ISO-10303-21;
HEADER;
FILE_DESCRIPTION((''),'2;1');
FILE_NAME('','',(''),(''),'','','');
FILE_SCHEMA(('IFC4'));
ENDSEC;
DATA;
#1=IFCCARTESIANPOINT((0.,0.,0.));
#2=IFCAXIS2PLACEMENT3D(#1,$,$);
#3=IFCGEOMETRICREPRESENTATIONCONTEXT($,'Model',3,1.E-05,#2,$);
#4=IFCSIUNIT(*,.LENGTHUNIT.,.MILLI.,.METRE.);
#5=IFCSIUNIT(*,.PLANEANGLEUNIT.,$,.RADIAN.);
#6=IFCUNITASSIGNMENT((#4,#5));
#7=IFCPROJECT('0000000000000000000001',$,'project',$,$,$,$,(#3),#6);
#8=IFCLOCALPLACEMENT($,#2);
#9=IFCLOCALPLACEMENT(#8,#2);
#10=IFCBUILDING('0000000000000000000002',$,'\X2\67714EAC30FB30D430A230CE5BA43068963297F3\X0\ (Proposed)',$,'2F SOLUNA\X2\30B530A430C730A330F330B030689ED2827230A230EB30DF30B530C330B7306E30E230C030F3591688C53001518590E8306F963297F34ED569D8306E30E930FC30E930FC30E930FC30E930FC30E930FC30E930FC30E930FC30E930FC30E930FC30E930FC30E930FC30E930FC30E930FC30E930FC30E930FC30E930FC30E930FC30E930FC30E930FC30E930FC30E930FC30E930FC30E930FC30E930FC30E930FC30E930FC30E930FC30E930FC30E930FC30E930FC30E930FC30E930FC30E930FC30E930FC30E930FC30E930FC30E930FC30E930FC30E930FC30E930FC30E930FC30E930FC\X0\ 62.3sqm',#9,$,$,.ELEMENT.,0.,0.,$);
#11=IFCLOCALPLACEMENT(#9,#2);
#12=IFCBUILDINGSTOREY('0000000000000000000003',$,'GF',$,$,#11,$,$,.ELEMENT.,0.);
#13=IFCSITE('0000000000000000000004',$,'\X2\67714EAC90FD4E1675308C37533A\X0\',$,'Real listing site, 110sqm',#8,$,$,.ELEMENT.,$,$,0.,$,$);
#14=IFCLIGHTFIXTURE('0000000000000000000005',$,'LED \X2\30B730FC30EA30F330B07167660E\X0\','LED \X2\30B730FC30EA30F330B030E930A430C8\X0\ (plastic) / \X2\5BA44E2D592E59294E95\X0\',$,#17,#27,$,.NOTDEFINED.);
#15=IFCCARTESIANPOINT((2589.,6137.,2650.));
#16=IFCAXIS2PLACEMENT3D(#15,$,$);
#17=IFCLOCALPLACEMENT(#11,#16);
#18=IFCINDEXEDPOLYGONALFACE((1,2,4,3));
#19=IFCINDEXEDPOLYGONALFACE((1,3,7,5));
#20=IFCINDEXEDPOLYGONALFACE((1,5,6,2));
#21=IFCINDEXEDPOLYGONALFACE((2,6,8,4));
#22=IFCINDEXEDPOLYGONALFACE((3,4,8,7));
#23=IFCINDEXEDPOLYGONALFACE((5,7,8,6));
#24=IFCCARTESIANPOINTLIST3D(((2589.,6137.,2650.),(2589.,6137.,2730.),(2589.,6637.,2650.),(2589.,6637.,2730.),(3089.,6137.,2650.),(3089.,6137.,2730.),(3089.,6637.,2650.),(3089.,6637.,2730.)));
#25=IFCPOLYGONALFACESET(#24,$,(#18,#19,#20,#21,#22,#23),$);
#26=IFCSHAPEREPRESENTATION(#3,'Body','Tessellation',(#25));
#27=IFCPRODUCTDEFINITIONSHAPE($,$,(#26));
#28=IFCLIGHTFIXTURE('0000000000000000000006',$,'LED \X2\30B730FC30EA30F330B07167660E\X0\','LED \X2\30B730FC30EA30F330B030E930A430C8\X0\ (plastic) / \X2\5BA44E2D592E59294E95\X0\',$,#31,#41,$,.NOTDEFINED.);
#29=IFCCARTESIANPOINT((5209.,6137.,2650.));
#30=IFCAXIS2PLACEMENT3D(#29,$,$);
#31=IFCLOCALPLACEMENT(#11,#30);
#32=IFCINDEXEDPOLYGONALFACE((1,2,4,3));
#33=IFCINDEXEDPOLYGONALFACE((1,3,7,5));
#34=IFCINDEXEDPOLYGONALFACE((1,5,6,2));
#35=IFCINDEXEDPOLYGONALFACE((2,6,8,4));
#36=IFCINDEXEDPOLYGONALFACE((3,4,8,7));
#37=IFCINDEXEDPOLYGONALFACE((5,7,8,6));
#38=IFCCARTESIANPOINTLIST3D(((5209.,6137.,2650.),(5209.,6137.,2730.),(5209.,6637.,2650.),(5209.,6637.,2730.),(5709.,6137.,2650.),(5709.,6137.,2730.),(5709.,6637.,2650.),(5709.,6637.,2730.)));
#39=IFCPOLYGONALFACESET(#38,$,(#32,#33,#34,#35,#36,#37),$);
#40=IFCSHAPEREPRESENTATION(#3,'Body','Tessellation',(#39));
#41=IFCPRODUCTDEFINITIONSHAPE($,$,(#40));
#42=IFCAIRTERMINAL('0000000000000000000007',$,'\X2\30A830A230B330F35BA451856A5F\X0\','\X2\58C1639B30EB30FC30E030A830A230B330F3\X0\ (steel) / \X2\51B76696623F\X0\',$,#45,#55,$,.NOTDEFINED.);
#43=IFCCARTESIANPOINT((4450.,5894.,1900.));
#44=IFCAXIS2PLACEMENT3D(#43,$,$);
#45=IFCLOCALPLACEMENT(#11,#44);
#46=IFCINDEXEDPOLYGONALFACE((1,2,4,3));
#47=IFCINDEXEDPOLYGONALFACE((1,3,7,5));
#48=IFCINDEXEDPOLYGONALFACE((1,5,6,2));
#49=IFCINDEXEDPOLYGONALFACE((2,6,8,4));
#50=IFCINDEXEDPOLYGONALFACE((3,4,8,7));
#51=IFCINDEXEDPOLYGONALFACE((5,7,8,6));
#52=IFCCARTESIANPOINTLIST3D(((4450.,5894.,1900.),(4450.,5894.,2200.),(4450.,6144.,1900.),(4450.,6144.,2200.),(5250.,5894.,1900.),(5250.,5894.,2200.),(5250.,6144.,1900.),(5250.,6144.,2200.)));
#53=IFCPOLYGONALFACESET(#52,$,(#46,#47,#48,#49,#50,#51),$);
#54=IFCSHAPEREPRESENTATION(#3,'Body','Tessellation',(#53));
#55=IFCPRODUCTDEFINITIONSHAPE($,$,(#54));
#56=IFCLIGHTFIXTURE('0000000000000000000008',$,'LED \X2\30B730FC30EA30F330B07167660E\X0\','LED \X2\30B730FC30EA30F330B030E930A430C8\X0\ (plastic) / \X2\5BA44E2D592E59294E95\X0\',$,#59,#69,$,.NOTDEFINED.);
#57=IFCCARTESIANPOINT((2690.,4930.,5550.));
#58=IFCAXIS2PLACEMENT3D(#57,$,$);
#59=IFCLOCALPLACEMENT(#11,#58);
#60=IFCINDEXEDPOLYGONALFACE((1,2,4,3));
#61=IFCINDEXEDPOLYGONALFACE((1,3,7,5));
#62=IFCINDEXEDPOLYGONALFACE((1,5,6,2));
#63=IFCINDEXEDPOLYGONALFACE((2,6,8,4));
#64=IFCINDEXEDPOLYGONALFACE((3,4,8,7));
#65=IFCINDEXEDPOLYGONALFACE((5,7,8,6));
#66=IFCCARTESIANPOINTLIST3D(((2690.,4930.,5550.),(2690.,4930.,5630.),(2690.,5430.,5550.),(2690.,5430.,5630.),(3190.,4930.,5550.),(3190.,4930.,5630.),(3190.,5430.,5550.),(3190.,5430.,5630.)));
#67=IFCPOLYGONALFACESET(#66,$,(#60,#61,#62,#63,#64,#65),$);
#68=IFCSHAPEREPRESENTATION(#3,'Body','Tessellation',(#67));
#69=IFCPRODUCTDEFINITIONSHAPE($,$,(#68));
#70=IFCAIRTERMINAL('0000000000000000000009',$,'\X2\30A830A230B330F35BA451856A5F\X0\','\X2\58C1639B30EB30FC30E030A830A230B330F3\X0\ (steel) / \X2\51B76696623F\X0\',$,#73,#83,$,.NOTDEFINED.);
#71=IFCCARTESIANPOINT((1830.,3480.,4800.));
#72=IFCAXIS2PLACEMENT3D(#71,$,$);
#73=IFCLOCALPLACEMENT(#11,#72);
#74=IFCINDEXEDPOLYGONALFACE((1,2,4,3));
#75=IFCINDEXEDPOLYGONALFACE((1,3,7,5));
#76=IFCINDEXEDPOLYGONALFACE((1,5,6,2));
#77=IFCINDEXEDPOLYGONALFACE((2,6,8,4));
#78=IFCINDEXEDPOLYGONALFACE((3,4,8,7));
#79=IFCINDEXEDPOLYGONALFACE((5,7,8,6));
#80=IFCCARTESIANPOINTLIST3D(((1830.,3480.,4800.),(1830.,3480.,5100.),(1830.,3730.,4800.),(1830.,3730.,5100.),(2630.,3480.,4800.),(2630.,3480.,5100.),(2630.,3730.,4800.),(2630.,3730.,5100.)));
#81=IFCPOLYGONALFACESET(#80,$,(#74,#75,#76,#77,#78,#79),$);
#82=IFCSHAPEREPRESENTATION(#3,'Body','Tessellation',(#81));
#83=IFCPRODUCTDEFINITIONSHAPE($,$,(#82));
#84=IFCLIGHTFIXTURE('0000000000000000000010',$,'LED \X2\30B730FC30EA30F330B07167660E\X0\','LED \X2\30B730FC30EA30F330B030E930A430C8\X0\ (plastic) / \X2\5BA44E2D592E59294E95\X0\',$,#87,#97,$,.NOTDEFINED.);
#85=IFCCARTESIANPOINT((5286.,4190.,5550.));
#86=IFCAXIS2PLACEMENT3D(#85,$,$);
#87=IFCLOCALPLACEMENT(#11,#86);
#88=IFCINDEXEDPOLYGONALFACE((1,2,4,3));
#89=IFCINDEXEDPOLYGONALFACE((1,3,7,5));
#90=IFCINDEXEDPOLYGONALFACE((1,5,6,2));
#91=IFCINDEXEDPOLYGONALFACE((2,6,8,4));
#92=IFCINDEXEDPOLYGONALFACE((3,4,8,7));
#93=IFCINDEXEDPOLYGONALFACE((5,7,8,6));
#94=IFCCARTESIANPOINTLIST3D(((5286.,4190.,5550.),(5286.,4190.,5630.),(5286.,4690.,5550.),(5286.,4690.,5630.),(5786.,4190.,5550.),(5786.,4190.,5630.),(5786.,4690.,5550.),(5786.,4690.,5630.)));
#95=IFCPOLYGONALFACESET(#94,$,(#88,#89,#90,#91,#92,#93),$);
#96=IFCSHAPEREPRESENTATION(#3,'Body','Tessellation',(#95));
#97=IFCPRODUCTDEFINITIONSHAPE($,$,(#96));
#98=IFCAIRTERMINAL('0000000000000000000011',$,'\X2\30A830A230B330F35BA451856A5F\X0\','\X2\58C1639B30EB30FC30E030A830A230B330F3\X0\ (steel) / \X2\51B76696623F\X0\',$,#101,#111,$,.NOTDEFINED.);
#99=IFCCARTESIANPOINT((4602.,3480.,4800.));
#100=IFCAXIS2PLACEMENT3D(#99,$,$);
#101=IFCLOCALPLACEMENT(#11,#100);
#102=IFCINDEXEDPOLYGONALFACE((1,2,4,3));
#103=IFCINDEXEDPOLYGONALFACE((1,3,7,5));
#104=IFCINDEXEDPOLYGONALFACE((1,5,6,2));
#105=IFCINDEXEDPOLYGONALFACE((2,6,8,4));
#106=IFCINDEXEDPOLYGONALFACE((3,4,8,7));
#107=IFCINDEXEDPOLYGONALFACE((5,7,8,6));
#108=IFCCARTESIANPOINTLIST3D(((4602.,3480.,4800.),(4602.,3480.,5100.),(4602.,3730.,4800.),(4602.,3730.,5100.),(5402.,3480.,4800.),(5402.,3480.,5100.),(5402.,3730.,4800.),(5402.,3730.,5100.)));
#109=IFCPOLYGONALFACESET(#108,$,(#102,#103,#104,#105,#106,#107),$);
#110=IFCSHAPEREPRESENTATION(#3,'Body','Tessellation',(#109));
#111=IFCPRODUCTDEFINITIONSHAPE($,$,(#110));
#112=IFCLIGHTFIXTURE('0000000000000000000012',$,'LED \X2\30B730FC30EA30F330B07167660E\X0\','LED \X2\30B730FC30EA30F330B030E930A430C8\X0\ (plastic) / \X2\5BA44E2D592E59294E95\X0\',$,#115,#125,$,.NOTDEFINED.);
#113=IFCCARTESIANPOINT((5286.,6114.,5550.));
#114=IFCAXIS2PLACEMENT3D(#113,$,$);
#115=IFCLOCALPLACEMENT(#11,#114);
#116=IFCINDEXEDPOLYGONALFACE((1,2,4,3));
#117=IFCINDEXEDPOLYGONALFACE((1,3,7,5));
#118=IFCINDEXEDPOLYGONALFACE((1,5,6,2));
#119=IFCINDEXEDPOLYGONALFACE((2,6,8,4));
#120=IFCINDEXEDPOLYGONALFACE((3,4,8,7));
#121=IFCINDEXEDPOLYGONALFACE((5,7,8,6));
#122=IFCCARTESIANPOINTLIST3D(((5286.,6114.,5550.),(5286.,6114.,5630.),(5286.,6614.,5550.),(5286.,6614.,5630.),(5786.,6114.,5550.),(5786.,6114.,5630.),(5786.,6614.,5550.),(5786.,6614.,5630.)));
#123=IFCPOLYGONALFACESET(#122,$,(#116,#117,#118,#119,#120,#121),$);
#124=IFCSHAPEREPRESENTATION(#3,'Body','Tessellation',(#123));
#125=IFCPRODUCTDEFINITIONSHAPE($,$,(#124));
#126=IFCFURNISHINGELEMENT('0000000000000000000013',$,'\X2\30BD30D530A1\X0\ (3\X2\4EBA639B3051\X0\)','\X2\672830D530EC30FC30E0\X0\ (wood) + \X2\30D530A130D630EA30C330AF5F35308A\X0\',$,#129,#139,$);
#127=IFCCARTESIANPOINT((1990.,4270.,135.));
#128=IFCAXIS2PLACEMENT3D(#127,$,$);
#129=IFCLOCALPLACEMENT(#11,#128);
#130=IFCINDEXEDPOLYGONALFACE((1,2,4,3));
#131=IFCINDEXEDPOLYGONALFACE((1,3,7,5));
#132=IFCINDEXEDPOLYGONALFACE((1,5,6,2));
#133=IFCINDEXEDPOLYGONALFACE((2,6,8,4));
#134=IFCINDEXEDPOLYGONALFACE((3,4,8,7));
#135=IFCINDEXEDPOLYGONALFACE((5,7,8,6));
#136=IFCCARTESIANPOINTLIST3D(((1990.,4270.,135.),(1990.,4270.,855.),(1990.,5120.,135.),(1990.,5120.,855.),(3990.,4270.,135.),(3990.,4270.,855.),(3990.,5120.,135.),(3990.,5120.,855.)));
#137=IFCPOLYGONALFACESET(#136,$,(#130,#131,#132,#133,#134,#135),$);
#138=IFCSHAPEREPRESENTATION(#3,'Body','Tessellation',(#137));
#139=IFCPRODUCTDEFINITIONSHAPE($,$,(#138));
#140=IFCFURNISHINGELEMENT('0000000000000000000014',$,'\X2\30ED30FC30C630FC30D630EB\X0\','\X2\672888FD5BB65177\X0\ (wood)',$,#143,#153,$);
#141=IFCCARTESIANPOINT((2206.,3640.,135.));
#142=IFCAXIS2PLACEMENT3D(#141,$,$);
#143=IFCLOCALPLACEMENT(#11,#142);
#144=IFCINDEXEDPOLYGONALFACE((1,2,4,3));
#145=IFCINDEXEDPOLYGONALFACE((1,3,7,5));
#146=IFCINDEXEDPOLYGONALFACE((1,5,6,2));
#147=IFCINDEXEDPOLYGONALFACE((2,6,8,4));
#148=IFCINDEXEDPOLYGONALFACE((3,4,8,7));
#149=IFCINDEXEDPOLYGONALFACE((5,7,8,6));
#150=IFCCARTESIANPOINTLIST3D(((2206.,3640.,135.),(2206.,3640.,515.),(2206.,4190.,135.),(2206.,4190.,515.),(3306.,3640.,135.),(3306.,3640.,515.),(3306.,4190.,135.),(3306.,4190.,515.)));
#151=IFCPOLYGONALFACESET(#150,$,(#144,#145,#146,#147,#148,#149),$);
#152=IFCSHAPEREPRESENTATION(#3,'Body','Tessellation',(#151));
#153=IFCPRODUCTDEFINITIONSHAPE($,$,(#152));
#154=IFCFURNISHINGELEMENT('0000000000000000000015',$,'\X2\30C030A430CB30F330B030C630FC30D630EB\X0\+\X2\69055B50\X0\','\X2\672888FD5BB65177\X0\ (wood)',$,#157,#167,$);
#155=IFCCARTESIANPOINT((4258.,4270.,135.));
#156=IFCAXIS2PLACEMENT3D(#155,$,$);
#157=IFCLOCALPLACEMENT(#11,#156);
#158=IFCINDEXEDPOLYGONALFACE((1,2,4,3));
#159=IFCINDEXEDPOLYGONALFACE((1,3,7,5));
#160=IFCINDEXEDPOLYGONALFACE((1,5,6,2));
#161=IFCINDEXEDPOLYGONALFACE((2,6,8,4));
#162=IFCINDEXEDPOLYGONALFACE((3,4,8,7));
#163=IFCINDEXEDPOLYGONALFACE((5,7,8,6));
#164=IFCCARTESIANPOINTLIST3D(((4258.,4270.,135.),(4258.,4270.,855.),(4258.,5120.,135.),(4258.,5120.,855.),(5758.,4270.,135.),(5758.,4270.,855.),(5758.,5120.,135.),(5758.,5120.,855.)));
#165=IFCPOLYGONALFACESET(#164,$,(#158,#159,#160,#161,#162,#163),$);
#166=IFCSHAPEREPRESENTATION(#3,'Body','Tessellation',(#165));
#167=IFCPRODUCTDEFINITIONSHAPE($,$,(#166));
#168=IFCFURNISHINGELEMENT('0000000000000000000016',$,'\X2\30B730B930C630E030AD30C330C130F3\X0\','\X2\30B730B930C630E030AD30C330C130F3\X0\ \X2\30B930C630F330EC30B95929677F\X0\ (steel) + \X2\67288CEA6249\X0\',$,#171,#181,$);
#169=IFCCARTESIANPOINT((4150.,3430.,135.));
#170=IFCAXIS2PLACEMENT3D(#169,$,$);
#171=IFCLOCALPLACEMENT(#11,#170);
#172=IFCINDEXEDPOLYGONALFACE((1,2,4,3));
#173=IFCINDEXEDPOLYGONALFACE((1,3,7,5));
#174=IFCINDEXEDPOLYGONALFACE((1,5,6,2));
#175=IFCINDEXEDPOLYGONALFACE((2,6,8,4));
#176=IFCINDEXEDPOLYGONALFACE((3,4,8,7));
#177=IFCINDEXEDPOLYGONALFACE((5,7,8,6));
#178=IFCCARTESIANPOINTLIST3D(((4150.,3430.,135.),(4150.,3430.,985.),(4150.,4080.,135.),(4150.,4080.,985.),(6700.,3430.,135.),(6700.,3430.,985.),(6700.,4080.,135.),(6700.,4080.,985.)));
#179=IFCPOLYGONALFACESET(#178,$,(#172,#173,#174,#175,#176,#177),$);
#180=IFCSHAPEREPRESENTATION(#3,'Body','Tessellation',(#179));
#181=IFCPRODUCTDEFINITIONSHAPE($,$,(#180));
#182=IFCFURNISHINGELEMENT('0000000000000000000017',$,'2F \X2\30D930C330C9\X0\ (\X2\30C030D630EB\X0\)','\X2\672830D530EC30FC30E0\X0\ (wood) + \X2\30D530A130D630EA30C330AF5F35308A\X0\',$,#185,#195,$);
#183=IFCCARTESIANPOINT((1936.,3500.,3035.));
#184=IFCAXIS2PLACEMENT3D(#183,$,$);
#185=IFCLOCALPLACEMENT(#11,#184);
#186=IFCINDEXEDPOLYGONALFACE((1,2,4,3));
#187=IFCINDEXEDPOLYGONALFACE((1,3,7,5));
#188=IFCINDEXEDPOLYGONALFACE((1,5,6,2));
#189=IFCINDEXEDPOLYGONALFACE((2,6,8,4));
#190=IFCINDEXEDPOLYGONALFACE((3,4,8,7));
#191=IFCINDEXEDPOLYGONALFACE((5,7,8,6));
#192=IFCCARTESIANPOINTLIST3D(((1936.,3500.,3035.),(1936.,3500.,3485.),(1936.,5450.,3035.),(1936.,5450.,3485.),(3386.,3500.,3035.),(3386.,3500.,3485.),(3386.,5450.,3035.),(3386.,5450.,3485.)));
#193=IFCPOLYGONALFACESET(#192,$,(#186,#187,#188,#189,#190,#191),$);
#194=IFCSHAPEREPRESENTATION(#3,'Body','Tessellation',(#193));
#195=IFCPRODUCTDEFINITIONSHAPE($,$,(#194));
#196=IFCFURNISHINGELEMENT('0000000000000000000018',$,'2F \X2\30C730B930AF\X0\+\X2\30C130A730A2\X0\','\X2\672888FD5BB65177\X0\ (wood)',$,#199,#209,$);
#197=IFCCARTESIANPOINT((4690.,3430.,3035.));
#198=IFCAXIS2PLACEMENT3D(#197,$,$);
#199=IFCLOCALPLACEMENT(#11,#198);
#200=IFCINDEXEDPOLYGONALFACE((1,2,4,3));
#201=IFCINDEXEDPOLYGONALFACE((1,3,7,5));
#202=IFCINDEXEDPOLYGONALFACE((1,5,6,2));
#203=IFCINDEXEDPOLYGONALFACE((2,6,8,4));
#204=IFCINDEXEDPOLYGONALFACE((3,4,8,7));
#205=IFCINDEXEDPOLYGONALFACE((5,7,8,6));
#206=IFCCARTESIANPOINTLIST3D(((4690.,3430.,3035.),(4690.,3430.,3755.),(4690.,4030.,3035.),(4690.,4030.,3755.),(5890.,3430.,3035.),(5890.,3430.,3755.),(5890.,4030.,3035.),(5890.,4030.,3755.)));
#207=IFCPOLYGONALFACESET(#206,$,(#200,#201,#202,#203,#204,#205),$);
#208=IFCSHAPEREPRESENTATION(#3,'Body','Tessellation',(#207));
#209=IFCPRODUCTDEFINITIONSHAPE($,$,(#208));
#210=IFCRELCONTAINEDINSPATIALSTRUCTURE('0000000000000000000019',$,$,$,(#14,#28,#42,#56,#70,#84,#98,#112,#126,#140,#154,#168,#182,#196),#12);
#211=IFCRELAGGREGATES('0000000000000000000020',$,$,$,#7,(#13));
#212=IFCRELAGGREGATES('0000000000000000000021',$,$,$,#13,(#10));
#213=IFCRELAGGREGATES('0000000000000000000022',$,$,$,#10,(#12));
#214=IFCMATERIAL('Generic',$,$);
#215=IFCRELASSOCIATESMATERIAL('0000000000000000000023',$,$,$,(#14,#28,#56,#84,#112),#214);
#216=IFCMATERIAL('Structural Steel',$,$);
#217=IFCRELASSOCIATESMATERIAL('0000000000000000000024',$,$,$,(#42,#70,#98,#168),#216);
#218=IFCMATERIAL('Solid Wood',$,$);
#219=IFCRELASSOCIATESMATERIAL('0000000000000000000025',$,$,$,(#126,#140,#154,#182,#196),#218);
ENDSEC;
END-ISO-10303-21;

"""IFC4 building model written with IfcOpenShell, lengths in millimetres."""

from ifc_helpers import new_model, si_unit, frame, frame_2d, origin, place, context, project, spatial, rectangle, extrude, material, element, save


model = new_model("IFC4")

# Units and contexts
model_context = context("Model", 3, precision=1e-05, world=origin())
ifc_project = project(units=[si_unit("LENGTHUNIT", "METRE", prefix="MILLI"), si_unit("PLANEANGLEUNIT", "RADIAN")], contexts=[model_context])

# Site, building, storey
site_placement = place(None, origin())
site = spatial("IfcSite", under=ifc_project, at=site_placement, Name="東京都世田谷区", ObjectType="Real listing site, 110sqm", CompositionType="ELEMENT", RefElevation=0.0)
building_placement = place(site_placement, origin())
building = spatial("IfcBuilding", under=site, at=building_placement, Name="東京・ピアノ室と防音 (Proposed)", ObjectType="2F SOLUNAサイディングと黒色アルミサッシのモダン外装、内部は防音仕様のラーラーラーラーラーラーラーラーラーラーラーラーラーラーラーラーラーラーラーラーラーラーラーラーラーラーラーラーラーラーラーラーラーラーラーラーラーラーラーラーラーラー 62.3sqm", CompositionType="ELEMENT", ElevationOfRefHeight=0.0, ElevationOfTerrain=0.0)
storey_placement = place(building_placement, origin())
storey = spatial("IfcBuildingStorey", under=building, at=storey_placement, Name="GF", CompositionType="ELEMENT", Elevation=0.0)

# Shared definitions
ifc_material_1 = material(Name="Solid Wood")

# Shared definitions
ifc_material_2 = material(Name="Structural Steel")

# Shared definitions
ifc_material_3 = material(Name="Generic")

# Light fixtures
light_fixture_1_placement = place(storey_placement, frame((2589.0, 6137.0, 2650.0)))
element("IfcLightFixture", 1, at=light_fixture_1_placement, inside=storey, material=ifc_material_3, Name="LED シーリング照明", Description="LED シーリングライト (plastic) / 室中央天井", PredefinedType="NOTDEFINED", context=model_context, shape_type="SweptSolid", body=[
    extrude(rectangle(XDim=500.0, YDim=500.0, at=frame_2d((250.0, 250.0))), frame((2589.0, 6137.0, 2650.0)), (0.0, 0.0, 1.0), 80.0),
])
light_fixture_2_placement = place(storey_placement, frame((5209.0, 6137.0, 2650.0)))
element("IfcLightFixture", 2, at=light_fixture_2_placement, inside=storey, material=ifc_material_3, Name="LED シーリング照明", Description="LED シーリングライト (plastic) / 室中央天井", PredefinedType="NOTDEFINED", context=model_context, shape_type="SweptSolid", body=[
    extrude(rectangle(XDim=500.0, YDim=500.0, at=frame_2d((250.0, 250.0))), frame((5209.0, 6137.0, 2650.0)), (0.0, 0.0, 1.0), 80.0),
])

# Air terminal
air_terminal_1_placement = place(storey_placement, frame((4450.0, 5894.0, 1900.0)))
element("IfcAirTerminal", 3, at=air_terminal_1_placement, inside=storey, material=ifc_material_2, Name="エアコン室内機", Description="壁掛ルームエアコン (steel) / 冷暖房", PredefinedType="NOTDEFINED", context=model_context, shape_type="SweptSolid", body=[
    extrude(rectangle(XDim=800.0, YDim=250.0, at=frame_2d((400.0, 125.0))), frame((4450.0, 5894.0, 1900.0)), (0.0, 0.0, 1.0), 300.0),
])

# Light fixture
light_fixture_3_placement = place(storey_placement, frame((2690.0, 4930.0, 5550.0)))
element("IfcLightFixture", 4, at=light_fixture_3_placement, inside=storey, material=ifc_material_3, Name="LED シーリング照明", Description="LED シーリングライト (plastic) / 室中央天井", PredefinedType="NOTDEFINED", context=model_context, shape_type="SweptSolid", body=[
    extrude(rectangle(XDim=500.0, YDim=500.0, at=frame_2d((250.0, 250.0))), frame((2690.0, 4930.0, 5550.0)), (0.0, 0.0, 1.0), 80.0),
])

# Air terminal
air_terminal_2_placement = place(storey_placement, frame((1830.0, 3480.0, 4800.0)))
element("IfcAirTerminal", 5, at=air_terminal_2_placement, inside=storey, material=ifc_material_2, Name="エアコン室内機", Description="壁掛ルームエアコン (steel) / 冷暖房", PredefinedType="NOTDEFINED", context=model_context, shape_type="SweptSolid", body=[
    extrude(rectangle(XDim=800.0, YDim=250.0, at=frame_2d((400.0, 125.0))), frame((1830.0, 3480.0, 4800.0)), (0.0, 0.0, 1.0), 300.0),
])

# Light fixture
light_fixture_4_placement = place(storey_placement, frame((5286.0, 4190.0, 5550.0)))
element("IfcLightFixture", 6, at=light_fixture_4_placement, inside=storey, material=ifc_material_3, Name="LED シーリング照明", Description="LED シーリングライト (plastic) / 室中央天井", PredefinedType="NOTDEFINED", context=model_context, shape_type="SweptSolid", body=[
    extrude(rectangle(XDim=500.0, YDim=500.0, at=frame_2d((250.0, 250.0))), frame((5286.0, 4190.0, 5550.0)), (0.0, 0.0, 1.0), 80.0),
])

# Air terminal
air_terminal_3_placement = place(storey_placement, frame((4602.0, 3480.0, 4800.0)))
element("IfcAirTerminal", 7, at=air_terminal_3_placement, inside=storey, material=ifc_material_2, Name="エアコン室内機", Description="壁掛ルームエアコン (steel) / 冷暖房", PredefinedType="NOTDEFINED", context=model_context, shape_type="SweptSolid", body=[
    extrude(rectangle(XDim=800.0, YDim=250.0, at=frame_2d((400.0, 125.0))), frame((4602.0, 3480.0, 4800.0)), (0.0, 0.0, 1.0), 300.0),
])

# Light fixture
light_fixture_5_placement = place(storey_placement, frame((5286.0, 6114.0, 5550.0)))
element("IfcLightFixture", 8, at=light_fixture_5_placement, inside=storey, material=ifc_material_3, Name="LED シーリング照明", Description="LED シーリングライト (plastic) / 室中央天井", PredefinedType="NOTDEFINED", context=model_context, shape_type="SweptSolid", body=[
    extrude(rectangle(XDim=500.0, YDim=500.0, at=frame_2d((250.0, 250.0))), frame((5286.0, 6114.0, 5550.0)), (0.0, 0.0, 1.0), 80.0),
])

# Furnishing elements
furnishing_1_placement = place(storey_placement, frame((1990.0, 4270.0, 135.0)))
element("IfcFurnishingElement", 9, at=furnishing_1_placement, inside=storey, material=ifc_material_1, Name="ソファ (3人掛け)", Description="木フレーム (wood) + ファブリック張り", context=model_context, shape_type="SweptSolid", body=[
    extrude(rectangle(XDim=2000.0, YDim=850.0, at=frame_2d((1000.0, 425.0))), frame((1990.0, 4270.0, 135.0)), (0.0, 0.0, 1.0), 720.0),
])
furnishing_2_placement = place(storey_placement, frame((2206.0, 3640.0, 135.0)))
element("IfcFurnishingElement", 10, at=furnishing_2_placement, inside=storey, material=ifc_material_1, Name="ローテーブル", Description="木製家具 (wood)", context=model_context, shape_type="SweptSolid", body=[
    extrude(rectangle(XDim=1100.0, YDim=550.0, at=frame_2d((550.0, 275.0))), frame((2206.0, 3640.0, 135.0)), (0.0, 0.0, 1.0), 380.0),
])
furnishing_3_placement = place(storey_placement, frame((4258.0, 4270.0, 135.0)))
element("IfcFurnishingElement", 11, at=furnishing_3_placement, inside=storey, material=ifc_material_1, Name="ダイニングテーブル+椅子", Description="木製家具 (wood)", context=model_context, shape_type="SweptSolid", body=[
    extrude(rectangle(XDim=1500.0, YDim=850.0, at=frame_2d((750.0, 425.0))), frame((4258.0, 4270.0, 135.0)), (0.0, 0.0, 1.0), 720.0),
])
furnishing_4_placement = place(storey_placement, frame((4150.0, 3430.0, 135.0)))
element("IfcFurnishingElement", 12, at=furnishing_4_placement, inside=storey, material=ifc_material_2, Name="システムキッチン", Description="システムキッチン ステンレス天板 (steel) + 木質扉", context=model_context, shape_type="SweptSolid", body=[
    extrude(rectangle(XDim=2550.0, YDim=650.0, at=frame_2d((1275.0, 325.0))), frame((4150.0, 3430.0, 135.0)), (0.0, 0.0, 1.0), 850.0),
])
furnishing_5_placement = place(storey_placement, frame((1936.0, 3500.0, 3035.0)))
element("IfcFurnishingElement", 13, at=furnishing_5_placement, inside=storey, material=ifc_material_1, Name="2F ベッド (ダブル)", Description="木フレーム (wood) + ファブリック張り", context=model_context, shape_type="SweptSolid", body=[
    extrude(rectangle(XDim=1450.0, YDim=1950.0, at=frame_2d((725.0, 975.0))), frame((1936.0, 3500.0, 3035.0)), (0.0, 0.0, 1.0), 450.0),
])
furnishing_6_placement = place(storey_placement, frame((4690.0, 3430.0, 3035.0)))
element("IfcFurnishingElement", 14, at=furnishing_6_placement, inside=storey, material=ifc_material_1, Name="2F デスク+チェア", Description="木製家具 (wood)", context=model_context, shape_type="SweptSolid", body=[
    extrude(rectangle(XDim=1200.0, YDim=600.0, at=frame_2d((600.0, 300.0))), frame((4690.0, 3430.0, 3035.0)), (0.0, 0.0, 1.0), 720.0),
])

save(model, "model.ifc")
